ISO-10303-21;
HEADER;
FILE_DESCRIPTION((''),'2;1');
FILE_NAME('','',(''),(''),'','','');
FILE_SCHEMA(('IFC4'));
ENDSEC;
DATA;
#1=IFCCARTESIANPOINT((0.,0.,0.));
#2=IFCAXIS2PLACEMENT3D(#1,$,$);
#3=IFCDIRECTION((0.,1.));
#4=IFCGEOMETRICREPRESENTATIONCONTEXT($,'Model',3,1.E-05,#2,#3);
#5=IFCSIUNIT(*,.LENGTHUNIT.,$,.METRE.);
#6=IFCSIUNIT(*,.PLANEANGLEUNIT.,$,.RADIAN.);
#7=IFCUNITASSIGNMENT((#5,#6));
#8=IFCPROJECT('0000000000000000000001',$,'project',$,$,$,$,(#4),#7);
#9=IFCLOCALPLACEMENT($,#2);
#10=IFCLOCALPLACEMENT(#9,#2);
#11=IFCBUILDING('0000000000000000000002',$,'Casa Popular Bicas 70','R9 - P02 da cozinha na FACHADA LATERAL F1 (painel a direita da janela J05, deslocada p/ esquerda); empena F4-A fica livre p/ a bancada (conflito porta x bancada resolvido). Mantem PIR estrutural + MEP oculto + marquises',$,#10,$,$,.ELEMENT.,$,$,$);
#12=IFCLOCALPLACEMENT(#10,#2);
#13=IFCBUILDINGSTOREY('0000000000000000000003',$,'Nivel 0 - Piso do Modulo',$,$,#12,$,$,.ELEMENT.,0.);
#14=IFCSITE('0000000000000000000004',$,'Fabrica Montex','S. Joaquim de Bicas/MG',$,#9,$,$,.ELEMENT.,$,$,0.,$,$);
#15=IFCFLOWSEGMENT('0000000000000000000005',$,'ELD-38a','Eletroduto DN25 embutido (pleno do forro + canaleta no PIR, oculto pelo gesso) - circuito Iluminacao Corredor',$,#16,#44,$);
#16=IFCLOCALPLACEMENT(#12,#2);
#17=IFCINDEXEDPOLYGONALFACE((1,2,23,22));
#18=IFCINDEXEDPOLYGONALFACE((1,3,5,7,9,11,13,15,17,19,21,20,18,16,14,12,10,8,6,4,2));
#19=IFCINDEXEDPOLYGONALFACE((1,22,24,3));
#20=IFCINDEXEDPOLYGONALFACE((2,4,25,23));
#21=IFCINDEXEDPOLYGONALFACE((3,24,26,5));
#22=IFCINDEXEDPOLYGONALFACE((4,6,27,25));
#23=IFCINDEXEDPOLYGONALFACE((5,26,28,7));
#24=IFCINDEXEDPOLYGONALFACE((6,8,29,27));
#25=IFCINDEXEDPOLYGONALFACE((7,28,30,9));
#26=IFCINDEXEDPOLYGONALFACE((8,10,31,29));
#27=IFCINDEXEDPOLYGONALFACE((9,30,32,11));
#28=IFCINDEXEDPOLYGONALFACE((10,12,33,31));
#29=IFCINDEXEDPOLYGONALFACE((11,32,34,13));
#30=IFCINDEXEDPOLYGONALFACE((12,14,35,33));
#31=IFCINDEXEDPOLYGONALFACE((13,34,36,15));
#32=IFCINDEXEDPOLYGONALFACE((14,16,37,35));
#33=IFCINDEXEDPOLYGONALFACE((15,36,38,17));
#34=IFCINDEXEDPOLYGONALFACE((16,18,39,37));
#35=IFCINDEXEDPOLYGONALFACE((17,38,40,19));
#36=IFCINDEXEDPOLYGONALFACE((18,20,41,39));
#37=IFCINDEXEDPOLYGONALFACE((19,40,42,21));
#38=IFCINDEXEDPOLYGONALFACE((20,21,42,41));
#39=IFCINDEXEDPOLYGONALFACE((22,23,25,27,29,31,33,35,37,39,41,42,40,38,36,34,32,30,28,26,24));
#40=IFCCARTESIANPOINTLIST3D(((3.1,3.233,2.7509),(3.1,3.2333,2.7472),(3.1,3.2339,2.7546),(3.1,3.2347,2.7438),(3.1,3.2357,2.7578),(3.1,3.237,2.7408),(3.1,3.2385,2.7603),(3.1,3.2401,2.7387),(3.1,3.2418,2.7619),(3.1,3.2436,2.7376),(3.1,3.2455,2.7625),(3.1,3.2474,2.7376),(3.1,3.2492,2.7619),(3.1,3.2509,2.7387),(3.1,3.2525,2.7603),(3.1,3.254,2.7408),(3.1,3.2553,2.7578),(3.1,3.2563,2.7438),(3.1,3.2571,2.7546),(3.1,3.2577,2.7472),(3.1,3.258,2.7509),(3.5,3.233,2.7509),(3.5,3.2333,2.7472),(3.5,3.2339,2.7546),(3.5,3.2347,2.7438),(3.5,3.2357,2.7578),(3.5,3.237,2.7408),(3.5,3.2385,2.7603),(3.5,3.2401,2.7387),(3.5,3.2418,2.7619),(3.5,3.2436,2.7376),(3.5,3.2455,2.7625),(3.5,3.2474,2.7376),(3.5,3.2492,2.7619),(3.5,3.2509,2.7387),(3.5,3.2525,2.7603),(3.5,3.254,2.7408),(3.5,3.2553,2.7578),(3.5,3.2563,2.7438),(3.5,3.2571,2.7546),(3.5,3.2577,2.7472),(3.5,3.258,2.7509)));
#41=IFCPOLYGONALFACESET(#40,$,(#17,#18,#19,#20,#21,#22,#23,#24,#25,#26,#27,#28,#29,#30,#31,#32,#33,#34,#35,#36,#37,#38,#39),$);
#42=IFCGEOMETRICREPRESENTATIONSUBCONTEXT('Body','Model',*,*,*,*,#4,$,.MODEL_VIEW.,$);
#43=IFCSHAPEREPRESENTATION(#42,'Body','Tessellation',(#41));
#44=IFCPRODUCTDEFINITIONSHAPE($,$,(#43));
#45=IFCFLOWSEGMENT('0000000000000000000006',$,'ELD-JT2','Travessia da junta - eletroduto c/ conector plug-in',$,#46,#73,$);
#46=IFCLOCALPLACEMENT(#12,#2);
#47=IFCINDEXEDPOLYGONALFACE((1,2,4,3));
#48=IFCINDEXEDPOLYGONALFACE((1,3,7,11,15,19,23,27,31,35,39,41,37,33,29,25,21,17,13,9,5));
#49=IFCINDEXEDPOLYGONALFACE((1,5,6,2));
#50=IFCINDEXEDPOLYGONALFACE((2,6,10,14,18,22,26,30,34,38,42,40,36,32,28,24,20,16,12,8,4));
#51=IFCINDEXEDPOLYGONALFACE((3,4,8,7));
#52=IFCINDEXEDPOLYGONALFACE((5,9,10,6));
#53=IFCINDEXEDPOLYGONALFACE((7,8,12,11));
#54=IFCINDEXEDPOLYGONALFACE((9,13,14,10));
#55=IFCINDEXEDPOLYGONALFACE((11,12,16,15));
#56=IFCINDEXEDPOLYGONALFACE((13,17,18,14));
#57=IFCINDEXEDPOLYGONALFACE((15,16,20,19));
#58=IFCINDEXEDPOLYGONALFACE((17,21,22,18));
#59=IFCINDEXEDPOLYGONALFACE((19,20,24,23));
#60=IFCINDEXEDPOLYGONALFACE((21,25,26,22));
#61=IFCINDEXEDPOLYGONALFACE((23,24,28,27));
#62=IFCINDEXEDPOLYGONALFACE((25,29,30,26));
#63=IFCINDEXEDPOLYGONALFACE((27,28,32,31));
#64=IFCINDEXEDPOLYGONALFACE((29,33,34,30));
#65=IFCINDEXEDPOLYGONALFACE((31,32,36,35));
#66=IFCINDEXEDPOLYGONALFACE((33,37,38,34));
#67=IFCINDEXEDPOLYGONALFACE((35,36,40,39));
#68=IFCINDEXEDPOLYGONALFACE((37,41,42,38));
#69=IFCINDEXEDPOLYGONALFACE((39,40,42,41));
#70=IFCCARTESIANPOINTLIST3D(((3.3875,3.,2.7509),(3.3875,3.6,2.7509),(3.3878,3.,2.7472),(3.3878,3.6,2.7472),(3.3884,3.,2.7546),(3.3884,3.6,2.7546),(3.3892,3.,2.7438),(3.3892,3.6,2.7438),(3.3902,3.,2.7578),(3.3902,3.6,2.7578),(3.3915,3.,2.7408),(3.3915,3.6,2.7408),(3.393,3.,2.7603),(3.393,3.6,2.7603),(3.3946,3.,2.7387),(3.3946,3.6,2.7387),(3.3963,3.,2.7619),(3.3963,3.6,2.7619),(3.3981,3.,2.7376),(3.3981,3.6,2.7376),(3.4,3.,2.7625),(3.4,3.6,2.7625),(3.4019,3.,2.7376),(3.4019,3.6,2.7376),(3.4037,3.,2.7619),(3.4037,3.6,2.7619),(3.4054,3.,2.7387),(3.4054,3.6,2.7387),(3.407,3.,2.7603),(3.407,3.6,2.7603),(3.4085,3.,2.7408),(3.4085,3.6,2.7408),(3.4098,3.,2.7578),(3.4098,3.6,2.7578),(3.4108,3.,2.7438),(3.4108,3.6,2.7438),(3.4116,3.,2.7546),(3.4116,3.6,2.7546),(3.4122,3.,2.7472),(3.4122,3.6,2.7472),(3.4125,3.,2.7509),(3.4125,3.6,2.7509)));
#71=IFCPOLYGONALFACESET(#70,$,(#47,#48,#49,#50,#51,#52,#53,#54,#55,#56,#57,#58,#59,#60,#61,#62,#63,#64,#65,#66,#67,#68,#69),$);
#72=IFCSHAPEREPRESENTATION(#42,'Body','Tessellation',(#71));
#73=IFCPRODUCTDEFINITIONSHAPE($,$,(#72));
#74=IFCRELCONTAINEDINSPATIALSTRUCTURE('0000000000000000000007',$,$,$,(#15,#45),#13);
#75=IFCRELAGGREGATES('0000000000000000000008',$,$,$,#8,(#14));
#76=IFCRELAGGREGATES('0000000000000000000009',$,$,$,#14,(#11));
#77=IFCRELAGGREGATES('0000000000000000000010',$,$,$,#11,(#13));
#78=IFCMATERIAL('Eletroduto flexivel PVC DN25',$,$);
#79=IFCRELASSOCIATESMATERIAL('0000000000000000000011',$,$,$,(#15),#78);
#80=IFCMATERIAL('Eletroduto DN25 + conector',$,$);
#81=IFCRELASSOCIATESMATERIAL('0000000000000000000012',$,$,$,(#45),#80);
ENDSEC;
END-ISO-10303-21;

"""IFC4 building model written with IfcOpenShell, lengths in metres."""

from ifc_helpers import new_model, si_unit, direction, frame, origin, origin_2d, place, context, subcontext, project, spatial, circle, extrude, material, element, save


model = new_model("IFC4")

# Units and contexts
model_context = context("Model", 3, precision=1e-05, world=origin(), true_north=direction((0.0, 1.0)))
body_context = subcontext(model_context, "Body", "Model", "MODEL_VIEW")
ifc_project = project(units=[si_unit("LENGTHUNIT", "METRE"), si_unit("PLANEANGLEUNIT", "RADIAN")], contexts=[model_context])

# Site, building, storey
site_placement = place(None, origin())
site = spatial("IfcSite", under=ifc_project, at=site_placement, Name="Fabrica Montex", Description="S. Joaquim de Bicas/MG", CompositionType="ELEMENT", RefElevation=0.0)
building_placement = place(site_placement, origin())
building = spatial("IfcBuilding", under=site, at=building_placement, Name="Casa Popular Bicas 70", Description="R9 - P02 da cozinha na FACHADA LATERAL F1 (painel a direita da janela J05, deslocada p/ esquerda); empena F4-A fica livre p/ a bancada (conflito porta x bancada resolvido). Mantem PIR estrutural + MEP oculto + marquises", CompositionType="ELEMENT")
storey_placement = place(building_placement, origin())
storey = spatial("IfcBuildingStorey", under=building, at=storey_placement, Name="Nivel 0 - Piso do Modulo", CompositionType="ELEMENT", Elevation=0.0)

# Flow segments
ifc_material_1 = material(Name="Eletroduto flexivel PVC DN25")
flow_segment_1_placement = place(storey_placement, frame((3.5, 3.2455, 2.75), z_axis=(-1.0, 0.0, 0.0), x_axis=(0.0, 0.0, 1.0)))
element("IfcFlowSegment", 1, at=flow_segment_1_placement, inside=storey, material=ifc_material_1, Name="ELD-38a", Description="Eletroduto DN25 embutido (pleno do forro + canaleta no PIR, oculto pelo gesso) - circuito Iluminacao Corredor", context=body_context, shape_type="SweptSolid", body=[
    extrude(circle(Radius=0.0125, at=origin_2d()), origin(), (0.0, 0.0, 1.0), 0.4),
])
ifc_material_2 = material(Name="Eletroduto DN25 + conector")
flow_segment_2_placement = place(storey_placement, frame((3.4, 3.0, 2.75), z_axis=(0.0, 1.0, 0.0), x_axis=(0.0, 0.0, 1.0)))
element("IfcFlowSegment", 2, at=flow_segment_2_placement, inside=storey, material=ifc_material_2, Name="ELD-JT2", Description="Travessia da junta - eletroduto c/ conector plug-in", context=body_context, shape_type="SweptSolid", body=[
    extrude(circle(Radius=0.0125, at=origin_2d()), origin(), (0.0, 0.0, 1.0), 0.6),
])

save(model, "model.ifc")
